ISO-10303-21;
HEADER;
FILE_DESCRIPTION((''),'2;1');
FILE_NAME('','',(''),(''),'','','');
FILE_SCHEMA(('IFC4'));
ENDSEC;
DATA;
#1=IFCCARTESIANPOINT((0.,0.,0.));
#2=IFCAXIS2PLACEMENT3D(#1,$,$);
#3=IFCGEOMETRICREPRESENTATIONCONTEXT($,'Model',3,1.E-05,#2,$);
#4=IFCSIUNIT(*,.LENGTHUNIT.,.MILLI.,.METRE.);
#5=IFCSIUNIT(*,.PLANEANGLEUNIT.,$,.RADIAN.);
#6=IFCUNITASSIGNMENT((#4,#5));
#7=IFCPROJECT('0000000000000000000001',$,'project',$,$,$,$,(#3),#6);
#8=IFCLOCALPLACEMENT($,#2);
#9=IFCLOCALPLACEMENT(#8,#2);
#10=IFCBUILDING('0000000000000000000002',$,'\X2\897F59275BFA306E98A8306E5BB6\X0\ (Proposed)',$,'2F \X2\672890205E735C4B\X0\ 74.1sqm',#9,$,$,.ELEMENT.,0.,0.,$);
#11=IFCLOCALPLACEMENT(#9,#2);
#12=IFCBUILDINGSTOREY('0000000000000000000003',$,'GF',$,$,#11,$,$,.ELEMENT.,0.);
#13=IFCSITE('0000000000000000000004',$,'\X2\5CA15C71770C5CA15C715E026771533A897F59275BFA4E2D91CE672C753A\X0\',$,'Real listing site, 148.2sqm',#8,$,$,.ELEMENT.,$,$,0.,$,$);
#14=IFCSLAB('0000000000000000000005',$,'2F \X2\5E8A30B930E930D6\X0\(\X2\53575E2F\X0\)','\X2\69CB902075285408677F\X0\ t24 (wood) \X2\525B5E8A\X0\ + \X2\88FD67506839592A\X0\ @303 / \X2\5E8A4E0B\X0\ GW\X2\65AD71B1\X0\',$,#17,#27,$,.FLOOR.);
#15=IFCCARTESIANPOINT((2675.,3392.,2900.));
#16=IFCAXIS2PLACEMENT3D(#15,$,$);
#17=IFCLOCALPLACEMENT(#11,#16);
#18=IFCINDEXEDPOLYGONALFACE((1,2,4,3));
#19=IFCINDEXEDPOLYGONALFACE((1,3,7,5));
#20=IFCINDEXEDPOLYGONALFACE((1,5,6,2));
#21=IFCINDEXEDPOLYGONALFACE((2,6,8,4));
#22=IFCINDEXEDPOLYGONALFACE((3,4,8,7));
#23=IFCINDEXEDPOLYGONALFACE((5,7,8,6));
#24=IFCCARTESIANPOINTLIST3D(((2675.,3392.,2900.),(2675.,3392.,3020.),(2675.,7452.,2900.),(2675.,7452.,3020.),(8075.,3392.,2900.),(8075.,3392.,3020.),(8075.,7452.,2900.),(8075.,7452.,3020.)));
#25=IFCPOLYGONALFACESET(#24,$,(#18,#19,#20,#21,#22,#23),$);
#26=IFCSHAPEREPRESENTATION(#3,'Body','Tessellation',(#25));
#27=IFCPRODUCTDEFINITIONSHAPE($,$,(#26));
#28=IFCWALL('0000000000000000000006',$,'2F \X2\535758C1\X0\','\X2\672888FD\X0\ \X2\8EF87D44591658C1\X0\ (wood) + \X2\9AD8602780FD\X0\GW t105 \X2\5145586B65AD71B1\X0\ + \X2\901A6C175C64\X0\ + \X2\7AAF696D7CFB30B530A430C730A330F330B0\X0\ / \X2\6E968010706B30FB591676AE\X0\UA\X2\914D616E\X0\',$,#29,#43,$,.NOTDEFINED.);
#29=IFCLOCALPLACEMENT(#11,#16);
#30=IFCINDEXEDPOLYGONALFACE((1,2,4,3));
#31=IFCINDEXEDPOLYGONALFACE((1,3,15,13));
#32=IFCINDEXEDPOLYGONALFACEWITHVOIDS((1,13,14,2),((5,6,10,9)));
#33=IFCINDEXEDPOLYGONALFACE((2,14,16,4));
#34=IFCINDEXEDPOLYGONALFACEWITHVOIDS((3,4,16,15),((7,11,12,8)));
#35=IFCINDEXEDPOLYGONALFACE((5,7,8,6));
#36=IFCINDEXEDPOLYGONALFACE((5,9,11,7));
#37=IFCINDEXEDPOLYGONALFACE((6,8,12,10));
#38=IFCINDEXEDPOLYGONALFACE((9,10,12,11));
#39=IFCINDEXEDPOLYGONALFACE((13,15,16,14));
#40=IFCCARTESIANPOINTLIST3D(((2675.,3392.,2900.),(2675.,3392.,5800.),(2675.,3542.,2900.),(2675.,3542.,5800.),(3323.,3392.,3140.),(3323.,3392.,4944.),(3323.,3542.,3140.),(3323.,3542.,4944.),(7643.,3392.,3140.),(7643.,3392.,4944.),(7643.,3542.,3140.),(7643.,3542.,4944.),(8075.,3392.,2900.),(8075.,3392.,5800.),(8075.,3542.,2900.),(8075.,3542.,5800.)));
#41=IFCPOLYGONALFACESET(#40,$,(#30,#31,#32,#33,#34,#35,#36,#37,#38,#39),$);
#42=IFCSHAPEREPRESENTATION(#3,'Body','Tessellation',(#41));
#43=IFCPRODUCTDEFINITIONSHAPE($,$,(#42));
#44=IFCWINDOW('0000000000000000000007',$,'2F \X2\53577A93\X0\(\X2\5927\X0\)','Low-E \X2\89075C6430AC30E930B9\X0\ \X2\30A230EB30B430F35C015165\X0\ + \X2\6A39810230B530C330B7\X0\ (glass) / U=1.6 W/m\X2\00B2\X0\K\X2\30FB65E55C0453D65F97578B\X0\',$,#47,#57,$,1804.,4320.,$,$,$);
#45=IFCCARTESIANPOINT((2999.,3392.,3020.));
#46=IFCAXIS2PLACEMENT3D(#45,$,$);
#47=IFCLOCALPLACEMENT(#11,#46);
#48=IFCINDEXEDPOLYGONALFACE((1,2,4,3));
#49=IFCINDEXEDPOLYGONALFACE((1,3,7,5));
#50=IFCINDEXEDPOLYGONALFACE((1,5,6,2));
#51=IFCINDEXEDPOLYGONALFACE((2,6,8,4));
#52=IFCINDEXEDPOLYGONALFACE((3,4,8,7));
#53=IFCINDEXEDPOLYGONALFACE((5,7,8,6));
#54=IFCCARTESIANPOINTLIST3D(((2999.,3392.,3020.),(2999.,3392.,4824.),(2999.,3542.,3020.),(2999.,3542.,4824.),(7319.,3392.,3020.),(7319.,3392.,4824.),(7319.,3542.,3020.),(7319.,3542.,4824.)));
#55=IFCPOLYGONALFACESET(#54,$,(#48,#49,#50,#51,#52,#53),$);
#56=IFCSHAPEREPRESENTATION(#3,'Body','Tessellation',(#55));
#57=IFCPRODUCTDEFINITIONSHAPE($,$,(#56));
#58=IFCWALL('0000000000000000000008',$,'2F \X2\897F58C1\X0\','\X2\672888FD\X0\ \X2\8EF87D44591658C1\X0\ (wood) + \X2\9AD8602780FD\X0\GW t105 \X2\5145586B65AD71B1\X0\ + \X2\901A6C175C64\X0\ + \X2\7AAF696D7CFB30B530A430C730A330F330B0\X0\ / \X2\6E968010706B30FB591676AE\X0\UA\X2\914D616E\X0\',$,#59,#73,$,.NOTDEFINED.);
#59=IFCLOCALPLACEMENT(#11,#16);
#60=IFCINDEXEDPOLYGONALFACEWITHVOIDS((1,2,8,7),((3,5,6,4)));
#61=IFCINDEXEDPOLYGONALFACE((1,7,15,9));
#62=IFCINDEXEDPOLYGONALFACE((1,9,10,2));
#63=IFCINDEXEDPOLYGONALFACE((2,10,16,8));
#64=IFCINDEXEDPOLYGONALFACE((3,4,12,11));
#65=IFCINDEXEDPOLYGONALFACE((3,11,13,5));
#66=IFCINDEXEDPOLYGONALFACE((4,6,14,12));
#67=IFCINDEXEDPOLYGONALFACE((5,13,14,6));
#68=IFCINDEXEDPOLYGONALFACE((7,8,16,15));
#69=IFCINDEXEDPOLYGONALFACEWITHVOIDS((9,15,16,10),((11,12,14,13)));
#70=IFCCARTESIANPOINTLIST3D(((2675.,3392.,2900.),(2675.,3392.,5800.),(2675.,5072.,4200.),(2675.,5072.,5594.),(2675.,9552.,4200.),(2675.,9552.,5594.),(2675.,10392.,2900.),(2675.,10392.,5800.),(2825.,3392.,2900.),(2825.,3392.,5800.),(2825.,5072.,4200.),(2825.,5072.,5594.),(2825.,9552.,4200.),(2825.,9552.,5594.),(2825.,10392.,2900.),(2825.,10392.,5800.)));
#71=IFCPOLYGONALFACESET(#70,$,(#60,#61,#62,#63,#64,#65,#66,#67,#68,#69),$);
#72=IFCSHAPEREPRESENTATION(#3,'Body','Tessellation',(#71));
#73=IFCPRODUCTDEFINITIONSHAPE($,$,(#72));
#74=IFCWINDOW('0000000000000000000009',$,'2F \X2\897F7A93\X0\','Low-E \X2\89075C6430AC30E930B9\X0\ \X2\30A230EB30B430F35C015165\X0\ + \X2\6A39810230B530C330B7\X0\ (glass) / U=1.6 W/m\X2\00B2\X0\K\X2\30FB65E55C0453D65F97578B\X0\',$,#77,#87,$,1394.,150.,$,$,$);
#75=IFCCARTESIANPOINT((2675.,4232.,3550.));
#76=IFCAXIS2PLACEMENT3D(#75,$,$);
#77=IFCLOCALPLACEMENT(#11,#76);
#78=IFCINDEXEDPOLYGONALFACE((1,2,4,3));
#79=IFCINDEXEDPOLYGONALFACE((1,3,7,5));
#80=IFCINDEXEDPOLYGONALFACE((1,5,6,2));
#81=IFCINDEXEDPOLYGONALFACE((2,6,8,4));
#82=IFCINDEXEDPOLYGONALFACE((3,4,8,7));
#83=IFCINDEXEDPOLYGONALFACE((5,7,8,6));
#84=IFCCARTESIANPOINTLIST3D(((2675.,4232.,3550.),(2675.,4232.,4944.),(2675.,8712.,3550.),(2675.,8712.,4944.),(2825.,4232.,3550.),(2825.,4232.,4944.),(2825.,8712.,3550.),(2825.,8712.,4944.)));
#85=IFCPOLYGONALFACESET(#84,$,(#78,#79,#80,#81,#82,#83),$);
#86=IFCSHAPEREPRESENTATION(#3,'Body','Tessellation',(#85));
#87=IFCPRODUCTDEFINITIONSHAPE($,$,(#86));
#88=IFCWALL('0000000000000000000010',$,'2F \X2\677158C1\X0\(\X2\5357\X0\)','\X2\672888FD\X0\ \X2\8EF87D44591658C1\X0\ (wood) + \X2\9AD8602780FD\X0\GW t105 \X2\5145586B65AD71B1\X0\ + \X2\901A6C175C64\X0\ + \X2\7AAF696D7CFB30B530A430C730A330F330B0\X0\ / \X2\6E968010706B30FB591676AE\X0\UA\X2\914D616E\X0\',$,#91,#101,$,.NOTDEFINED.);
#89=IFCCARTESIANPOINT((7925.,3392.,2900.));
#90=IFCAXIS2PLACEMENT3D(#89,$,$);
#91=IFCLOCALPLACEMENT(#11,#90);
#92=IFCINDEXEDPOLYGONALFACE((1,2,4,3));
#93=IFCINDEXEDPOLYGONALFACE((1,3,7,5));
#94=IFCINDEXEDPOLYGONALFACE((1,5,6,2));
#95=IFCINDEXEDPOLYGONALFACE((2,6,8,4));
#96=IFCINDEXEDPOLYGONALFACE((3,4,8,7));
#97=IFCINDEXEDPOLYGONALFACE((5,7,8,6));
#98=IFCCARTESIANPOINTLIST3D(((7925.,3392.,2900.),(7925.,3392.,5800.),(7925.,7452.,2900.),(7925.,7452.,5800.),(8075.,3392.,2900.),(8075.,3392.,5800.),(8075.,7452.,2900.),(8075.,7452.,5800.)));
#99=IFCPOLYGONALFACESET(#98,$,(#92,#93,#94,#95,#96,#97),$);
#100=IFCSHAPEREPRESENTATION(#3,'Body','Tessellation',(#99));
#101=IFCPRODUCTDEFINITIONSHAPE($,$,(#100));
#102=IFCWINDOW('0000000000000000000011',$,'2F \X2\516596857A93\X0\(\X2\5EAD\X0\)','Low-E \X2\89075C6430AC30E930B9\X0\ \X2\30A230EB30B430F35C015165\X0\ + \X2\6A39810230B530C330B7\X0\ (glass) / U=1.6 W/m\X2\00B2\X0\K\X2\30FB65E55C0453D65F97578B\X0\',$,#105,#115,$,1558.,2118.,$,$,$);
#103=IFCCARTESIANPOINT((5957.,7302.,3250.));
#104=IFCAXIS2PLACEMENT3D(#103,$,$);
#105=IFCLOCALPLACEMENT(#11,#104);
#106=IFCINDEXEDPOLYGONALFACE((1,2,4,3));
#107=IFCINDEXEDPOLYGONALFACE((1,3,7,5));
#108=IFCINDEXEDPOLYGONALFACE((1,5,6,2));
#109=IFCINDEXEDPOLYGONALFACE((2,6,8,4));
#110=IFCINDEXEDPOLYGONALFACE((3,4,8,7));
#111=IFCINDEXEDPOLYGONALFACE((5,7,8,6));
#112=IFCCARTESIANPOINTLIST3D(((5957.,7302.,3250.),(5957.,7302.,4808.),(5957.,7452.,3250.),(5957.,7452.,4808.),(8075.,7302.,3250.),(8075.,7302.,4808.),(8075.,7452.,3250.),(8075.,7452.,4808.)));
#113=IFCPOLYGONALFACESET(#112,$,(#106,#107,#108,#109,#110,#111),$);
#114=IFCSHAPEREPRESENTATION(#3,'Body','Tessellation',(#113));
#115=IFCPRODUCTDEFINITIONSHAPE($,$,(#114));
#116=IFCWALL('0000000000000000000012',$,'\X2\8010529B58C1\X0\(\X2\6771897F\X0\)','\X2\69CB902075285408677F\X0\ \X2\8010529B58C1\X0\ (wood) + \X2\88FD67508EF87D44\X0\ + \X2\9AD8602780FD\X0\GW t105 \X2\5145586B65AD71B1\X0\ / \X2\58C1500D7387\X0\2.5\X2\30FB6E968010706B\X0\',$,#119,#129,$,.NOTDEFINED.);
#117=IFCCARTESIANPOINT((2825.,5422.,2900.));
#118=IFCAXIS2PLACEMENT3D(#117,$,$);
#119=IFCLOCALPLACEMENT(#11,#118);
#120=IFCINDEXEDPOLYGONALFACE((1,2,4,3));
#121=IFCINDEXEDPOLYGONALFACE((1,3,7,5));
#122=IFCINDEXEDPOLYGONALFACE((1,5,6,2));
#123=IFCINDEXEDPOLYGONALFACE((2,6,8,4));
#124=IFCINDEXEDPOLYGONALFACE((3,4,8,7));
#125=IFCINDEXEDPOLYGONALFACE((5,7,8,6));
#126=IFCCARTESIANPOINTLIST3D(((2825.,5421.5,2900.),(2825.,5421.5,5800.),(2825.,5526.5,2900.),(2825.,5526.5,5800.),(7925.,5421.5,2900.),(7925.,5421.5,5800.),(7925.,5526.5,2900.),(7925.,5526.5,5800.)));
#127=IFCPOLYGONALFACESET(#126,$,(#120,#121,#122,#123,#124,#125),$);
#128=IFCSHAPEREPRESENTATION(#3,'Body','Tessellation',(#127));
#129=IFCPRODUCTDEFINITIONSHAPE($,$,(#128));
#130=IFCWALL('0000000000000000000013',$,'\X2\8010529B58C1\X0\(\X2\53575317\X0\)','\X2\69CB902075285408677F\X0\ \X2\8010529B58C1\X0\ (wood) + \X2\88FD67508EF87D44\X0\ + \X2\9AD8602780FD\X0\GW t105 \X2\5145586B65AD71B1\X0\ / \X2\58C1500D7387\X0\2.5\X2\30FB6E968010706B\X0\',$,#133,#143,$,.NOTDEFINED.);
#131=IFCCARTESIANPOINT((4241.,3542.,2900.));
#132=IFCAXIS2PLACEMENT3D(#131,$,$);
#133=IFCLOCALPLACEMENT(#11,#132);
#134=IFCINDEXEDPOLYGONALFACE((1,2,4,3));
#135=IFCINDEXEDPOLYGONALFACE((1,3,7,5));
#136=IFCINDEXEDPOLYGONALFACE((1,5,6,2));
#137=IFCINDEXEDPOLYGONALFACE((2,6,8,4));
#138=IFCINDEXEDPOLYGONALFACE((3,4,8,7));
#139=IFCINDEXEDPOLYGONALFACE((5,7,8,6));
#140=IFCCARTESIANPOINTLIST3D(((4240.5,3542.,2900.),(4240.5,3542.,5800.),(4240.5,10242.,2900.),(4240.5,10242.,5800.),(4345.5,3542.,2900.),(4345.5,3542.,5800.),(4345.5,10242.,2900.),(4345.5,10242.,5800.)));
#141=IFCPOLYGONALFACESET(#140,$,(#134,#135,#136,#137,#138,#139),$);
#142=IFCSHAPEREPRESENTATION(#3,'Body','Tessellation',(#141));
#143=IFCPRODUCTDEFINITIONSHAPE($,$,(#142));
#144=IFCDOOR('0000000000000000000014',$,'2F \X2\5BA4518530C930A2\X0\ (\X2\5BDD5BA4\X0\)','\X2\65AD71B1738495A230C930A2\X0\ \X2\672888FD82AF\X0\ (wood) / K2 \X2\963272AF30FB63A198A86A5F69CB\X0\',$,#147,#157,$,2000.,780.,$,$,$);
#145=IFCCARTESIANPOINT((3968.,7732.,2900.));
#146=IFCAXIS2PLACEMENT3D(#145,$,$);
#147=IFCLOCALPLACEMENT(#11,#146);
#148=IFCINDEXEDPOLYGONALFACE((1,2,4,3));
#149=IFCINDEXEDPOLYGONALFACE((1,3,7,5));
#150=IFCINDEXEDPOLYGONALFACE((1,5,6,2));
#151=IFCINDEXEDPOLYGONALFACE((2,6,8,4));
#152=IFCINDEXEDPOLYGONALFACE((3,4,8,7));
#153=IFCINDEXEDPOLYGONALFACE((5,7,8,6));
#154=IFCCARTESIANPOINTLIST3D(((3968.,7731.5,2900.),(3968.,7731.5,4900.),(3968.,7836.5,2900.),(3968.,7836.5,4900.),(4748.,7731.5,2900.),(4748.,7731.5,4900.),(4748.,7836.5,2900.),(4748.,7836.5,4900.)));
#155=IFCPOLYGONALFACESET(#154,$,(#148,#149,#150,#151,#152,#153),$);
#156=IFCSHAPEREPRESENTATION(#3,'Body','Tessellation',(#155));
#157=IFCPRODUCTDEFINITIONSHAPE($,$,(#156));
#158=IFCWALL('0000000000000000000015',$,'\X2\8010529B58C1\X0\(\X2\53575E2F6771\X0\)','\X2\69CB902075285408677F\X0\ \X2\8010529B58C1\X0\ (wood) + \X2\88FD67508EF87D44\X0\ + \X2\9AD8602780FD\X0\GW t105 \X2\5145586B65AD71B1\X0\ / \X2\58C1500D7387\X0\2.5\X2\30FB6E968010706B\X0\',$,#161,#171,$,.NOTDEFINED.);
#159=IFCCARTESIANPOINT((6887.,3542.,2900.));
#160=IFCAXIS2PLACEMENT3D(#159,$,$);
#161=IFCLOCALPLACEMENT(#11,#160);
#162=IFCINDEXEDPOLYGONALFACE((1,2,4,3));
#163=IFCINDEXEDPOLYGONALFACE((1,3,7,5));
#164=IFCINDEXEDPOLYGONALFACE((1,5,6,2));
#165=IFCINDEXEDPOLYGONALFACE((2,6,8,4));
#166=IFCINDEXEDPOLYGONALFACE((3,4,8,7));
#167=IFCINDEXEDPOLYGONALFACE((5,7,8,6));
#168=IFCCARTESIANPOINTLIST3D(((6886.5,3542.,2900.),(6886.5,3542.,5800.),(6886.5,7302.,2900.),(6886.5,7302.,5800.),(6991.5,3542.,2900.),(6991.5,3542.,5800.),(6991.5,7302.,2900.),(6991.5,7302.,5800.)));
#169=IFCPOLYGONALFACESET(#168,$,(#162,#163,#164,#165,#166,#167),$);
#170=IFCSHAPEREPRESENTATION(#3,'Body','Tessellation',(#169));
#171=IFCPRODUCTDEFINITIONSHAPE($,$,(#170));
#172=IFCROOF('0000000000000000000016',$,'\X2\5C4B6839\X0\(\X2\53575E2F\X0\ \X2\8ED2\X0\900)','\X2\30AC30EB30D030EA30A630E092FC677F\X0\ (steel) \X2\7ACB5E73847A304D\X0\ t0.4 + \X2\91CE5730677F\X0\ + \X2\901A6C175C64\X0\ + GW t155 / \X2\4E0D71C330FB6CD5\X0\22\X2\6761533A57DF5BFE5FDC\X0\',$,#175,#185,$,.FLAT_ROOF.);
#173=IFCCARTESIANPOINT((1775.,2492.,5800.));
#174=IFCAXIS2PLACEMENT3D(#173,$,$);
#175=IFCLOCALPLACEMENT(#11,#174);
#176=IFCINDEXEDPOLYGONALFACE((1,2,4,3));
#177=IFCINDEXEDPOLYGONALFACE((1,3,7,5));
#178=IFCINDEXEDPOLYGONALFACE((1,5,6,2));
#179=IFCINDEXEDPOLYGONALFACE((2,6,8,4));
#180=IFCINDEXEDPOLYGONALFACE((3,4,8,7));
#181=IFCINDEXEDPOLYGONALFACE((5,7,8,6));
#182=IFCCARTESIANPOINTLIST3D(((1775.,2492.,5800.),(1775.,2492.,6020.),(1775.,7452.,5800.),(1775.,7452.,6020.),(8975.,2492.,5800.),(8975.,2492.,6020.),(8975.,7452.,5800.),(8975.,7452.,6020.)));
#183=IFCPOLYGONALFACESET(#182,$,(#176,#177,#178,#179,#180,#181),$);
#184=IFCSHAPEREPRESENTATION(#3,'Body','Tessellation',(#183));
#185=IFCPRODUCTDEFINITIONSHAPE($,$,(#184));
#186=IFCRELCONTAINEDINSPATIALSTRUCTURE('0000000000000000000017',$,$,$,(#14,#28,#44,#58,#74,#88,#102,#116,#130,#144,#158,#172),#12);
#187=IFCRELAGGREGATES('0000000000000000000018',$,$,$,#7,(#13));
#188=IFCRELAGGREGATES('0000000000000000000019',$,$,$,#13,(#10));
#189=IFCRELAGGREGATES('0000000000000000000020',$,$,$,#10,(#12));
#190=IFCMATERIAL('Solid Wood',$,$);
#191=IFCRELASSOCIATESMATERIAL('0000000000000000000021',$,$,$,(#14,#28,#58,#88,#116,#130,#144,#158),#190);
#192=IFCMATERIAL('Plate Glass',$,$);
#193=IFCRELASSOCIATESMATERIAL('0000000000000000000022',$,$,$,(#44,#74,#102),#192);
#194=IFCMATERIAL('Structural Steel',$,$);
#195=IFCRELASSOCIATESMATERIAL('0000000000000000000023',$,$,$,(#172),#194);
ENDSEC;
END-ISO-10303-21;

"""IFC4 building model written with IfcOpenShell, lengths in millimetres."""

from ifc_helpers import new_model, si_unit, frame, frame_2d, origin, place, context, project, spatial, rectangle, extrude, material, element, fill, save


model = new_model("IFC4")

# Units and contexts
model_context = context("Model", 3, precision=1e-05, world=origin())
ifc_project = project(units=[si_unit("LENGTHUNIT", "METRE", prefix="MILLI"), si_unit("PLANEANGLEUNIT", "RADIAN")], contexts=[model_context])

# Site, building, storey
site_placement = place(None, origin())
site = spatial("IfcSite", under=ifc_project, at=site_placement, Name="岡山県岡山市東区西大寺中野本町", ObjectType="Real listing site, 148.2sqm", CompositionType="ELEMENT", RefElevation=0.0)
building_placement = place(site_placement, origin())
building = spatial("IfcBuilding", under=site, at=building_placement, Name="西大寺の風の家 (Proposed)", ObjectType="2F 木造平屋 74.1sqm", CompositionType="ELEMENT", ElevationOfRefHeight=0.0, ElevationOfTerrain=0.0)
storey_placement = place(building_placement, origin())
storey = spatial("IfcBuildingStorey", under=building, at=storey_placement, Name="GF", CompositionType="ELEMENT", Elevation=0.0)

# Slab
ifc_material_1 = material(Name="Solid Wood")
slab_placement = place(storey_placement, frame((2675.0, 3392.0, 2900.0)))
element("IfcSlab", 1, at=slab_placement, inside=storey, material=ifc_material_1, Name="2F 床スラブ(南帯)", Description="構造用合板 t24 (wood) 剛床 + 製材根太 @303 / 床下 GW断熱", PredefinedType="FLOOR", context=model_context, shape_type="SweptSolid", body=[
    extrude(rectangle(XDim=5400.0, YDim=4060.0, at=frame_2d((2700.0, 2030.0))), frame((2675.0, 3392.0, 2900.0)), (0.0, 0.0, 1.0), 120.0),
])

# Walls, openings, windows
wall_1_placement = place(storey_placement, frame((2675.0, 3392.0, 2900.0)))
wall_1 = element("IfcWall", 2, at=wall_1_placement, inside=storey, material=ifc_material_1, Name="2F 南壁", Description="木製 軸組外壁 (wood) + 高性能GW t105 充填断熱 + 通気層 + 窯業系サイディング / 準耐火・外皮UA配慮", PredefinedType="NOTDEFINED", context=model_context, shape_type="SweptSolid", body=[
    extrude(rectangle(XDim=5400.0, YDim=150.0, at=frame_2d((2700.0, 75.0))), frame((2675.0, 3392.0, 2900.0)), (0.0, 0.0, 1.0), 2900.0),
])
opening_1_placement = place(storey_placement, frame((2999.0, 3392.0, 3020.0)))
opening_1 = element("IfcOpeningElement", 3, at=opening_1_placement, cuts=wall_1, PredefinedType="NOTDEFINED", context=model_context, shape_type="SweptSolid", body=[
    extrude(rectangle(XDim=4320.0, YDim=150.0, at=frame_2d((2160.0, 75.0))), frame((2999.0, 3392.0, 3020.0)), (0.0, 0.0, 1.0), 1804.0),
])
ifc_material_2 = material(Name="Plate Glass")
window_1_placement = place(storey_placement, frame((2999.0, 3392.0, 3020.0)))
window_1 = element("IfcWindow", 4, at=window_1_placement, inside=storey, material=ifc_material_2, Name="2F 南窓(大)", Description="Low-E 複層ガラス アルゴン封入 + 樹脂サッシ (glass) / U=1.6 W/m²K・日射取得型", OverallHeight=1804.0, OverallWidth=4320.0, context=model_context, shape_type="SweptSolid", body=[
    extrude(rectangle(XDim=4320.0, YDim=150.0, at=frame_2d((2160.0, 75.0))), frame((2999.0, 3392.0, 3020.0)), (0.0, 0.0, 1.0), 1804.0),
])
fill(opening_1, window_1)
wall_2_placement = place(storey_placement, frame((2675.0, 3392.0, 2900.0)))
wall_2 = element("IfcWall", 5, at=wall_2_placement, inside=storey, material=ifc_material_1, Name="2F 西壁", Description="木製 軸組外壁 (wood) + 高性能GW t105 充填断熱 + 通気層 + 窯業系サイディング / 準耐火・外皮UA配慮", PredefinedType="NOTDEFINED", context=model_context, shape_type="SweptSolid", body=[
    extrude(rectangle(XDim=150.0, YDim=7000.0, at=frame_2d((75.0, 3500.0))), frame((2675.0, 3392.0, 2900.0)), (0.0, 0.0, 1.0), 2900.0),
])
opening_2_placement = place(storey_placement, frame((2675.0, 4232.0, 3550.0)))
opening_2 = element("IfcOpeningElement", 6, at=opening_2_placement, cuts=wall_2, PredefinedType="NOTDEFINED", context=model_context, shape_type="SweptSolid", body=[
    extrude(rectangle(XDim=150.0, YDim=4480.0, at=frame_2d((75.0, 2240.0))), frame((2675.0, 4232.0, 3550.0)), (0.0, 0.0, 1.0), 1394.0),
])
window_2_placement = place(storey_placement, frame((2675.0, 4232.0, 3550.0)))
window_2 = element("IfcWindow", 7, at=window_2_placement, inside=storey, material=ifc_material_2, Name="2F 西窓", Description="Low-E 複層ガラス アルゴン封入 + 樹脂サッシ (glass) / U=1.6 W/m²K・日射取得型", OverallHeight=1394.0, OverallWidth=150.0, context=model_context, shape_type="SweptSolid", body=[
    extrude(rectangle(XDim=150.0, YDim=4480.0, at=frame_2d((75.0, 2240.0))), frame((2675.0, 4232.0, 3550.0)), (0.0, 0.0, 1.0), 1394.0),
])
fill(opening_2, window_2)
wall_3_placement = place(storey_placement, frame((7925.0, 3392.0, 2900.0)))
wall_3 = element("IfcWall", 8, at=wall_3_placement, inside=storey, material=ifc_material_1, Name="2F 東壁(南)", Description="木製 軸組外壁 (wood) + 高性能GW t105 充填断熱 + 通気層 + 窯業系サイディング / 準耐火・外皮UA配慮", PredefinedType="NOTDEFINED", context=model_context, shape_type="SweptSolid", body=[
    extrude(rectangle(XDim=150.0, YDim=4060.0, at=frame_2d((75.0, 2030.0))), frame((7925.0, 3392.0, 2900.0)), (0.0, 0.0, 1.0), 2900.0),
])
opening_3_placement = place(storey_placement, frame((5957.0, 7302.0, 3250.0)))
opening_3 = element("IfcOpeningElement", 9, at=opening_3_placement, cuts=wall_3, PredefinedType="NOTDEFINED", context=model_context, shape_type="SweptSolid", body=[
    extrude(rectangle(XDim=2118.0, YDim=150.0, at=frame_2d((1059.0, 75.0))), frame((5957.0, 7302.0, 3250.0)), (0.0, 0.0, 1.0), 1558.0),
])
window_3_placement = place(storey_placement, frame((5957.0, 7302.0, 3250.0)))
window_3 = element("IfcWindow", 10, at=window_3_placement, inside=storey, material=ifc_material_2, Name="2F 入隅窓(庭)", Description="Low-E 複層ガラス アルゴン封入 + 樹脂サッシ (glass) / U=1.6 W/m²K・日射取得型", OverallHeight=1558.0, OverallWidth=2118.0, context=model_context, shape_type="SweptSolid", body=[
    extrude(rectangle(XDim=2118.0, YDim=150.0, at=frame_2d((1059.0, 75.0))), frame((5957.0, 7302.0, 3250.0)), (0.0, 0.0, 1.0), 1558.0),
])
fill(opening_3, window_3)

# Wall
wall_4_placement = place(storey_placement, frame((2825.0, 5422.0, 2900.0)))
element("IfcWall", 11, at=wall_4_placement, inside=storey, material=ifc_material_1, Name="耐力壁(東西)", Description="構造用合板 耐力壁 (wood) + 製材軸組 + 高性能GW t105 充填断熱 / 壁倍率2.5・準耐火", PredefinedType="NOTDEFINED", context=model_context, shape_type="SweptSolid", body=[
    extrude(rectangle(XDim=5100.0, YDim=105.0, at=frame_2d((2550.0, 52.0))), frame((2825.0, 5422.0, 2900.0)), (0.0, 0.0, 1.0), 2900.0),
])

# Wall, opening, door
wall_5_placement = place(storey_placement, frame((4241.0, 3542.0, 2900.0)))
wall_5 = element("IfcWall", 12, at=wall_5_placement, inside=storey, material=ifc_material_1, Name="耐力壁(南北)", Description="構造用合板 耐力壁 (wood) + 製材軸組 + 高性能GW t105 充填断熱 / 壁倍率2.5・準耐火", PredefinedType="NOTDEFINED", context=model_context, shape_type="SweptSolid", body=[
    extrude(rectangle(XDim=105.0, YDim=6700.0, at=frame_2d((52.0, 3350.0))), frame((4241.0, 3542.0, 2900.0)), (0.0, 0.0, 1.0), 2900.0),
])
opening_4_placement = place(storey_placement, frame((3968.0, 7732.0, 2900.0)))
opening_4 = element("IfcOpeningElement", 13, at=opening_4_placement, cuts=wall_5, PredefinedType="NOTDEFINED", context=model_context, shape_type="SweptSolid", body=[
    extrude(rectangle(XDim=780.0, YDim=105.0, at=frame_2d((390.0, 52.0))), frame((3968.0, 7732.0, 2900.0)), (0.0, 0.0, 1.0), 2000.0),
])
door_placement = place(storey_placement, frame((3968.0, 7732.0, 2900.0)))
door = element("IfcDoor", 14, at=door_placement, inside=storey, material=ifc_material_1, Name="2F 室内ドア (寝室)", Description="断熱玄関ドア 木製芯 (wood) / K2 防犯・採風機構", OverallHeight=2000.0, OverallWidth=780.0, context=model_context, shape_type="SweptSolid", body=[
    extrude(rectangle(XDim=780.0, YDim=105.0, at=frame_2d((390.0, 52.0))), frame((3968.0, 7732.0, 2900.0)), (0.0, 0.0, 1.0), 2000.0),
])
fill(opening_4, door)

# Wall
wall_6_placement = place(storey_placement, frame((6887.0, 3542.0, 2900.0)))
element("IfcWall", 15, at=wall_6_placement, inside=storey, material=ifc_material_1, Name="耐力壁(南帯東)", Description="構造用合板 耐力壁 (wood) + 製材軸組 + 高性能GW t105 充填断熱 / 壁倍率2.5・準耐火", PredefinedType="NOTDEFINED", context=model_context, shape_type="SweptSolid", body=[
    extrude(rectangle(XDim=105.0, YDim=3760.0, at=frame_2d((52.0, 1880.0))), frame((6887.0, 3542.0, 2900.0)), (0.0, 0.0, 1.0), 2900.0),
])

# Roof
ifc_material_3 = material(Name="Structural Steel")
for number, where, name in (
    (16, (1775.0, 2492.0, 5800.0), "屋根(南帯 軒900)"),
):
    element("IfcRoof", number, at=place(storey_placement, frame(where)), inside=storey, material=ifc_material_3, Name=name, Description="ガルバリウム鋼板 (steel) 立平葺き t0.4 + 野地板 + 通気層 + GW t155 / 不燃・法22条区域対応", PredefinedType="FLAT_ROOF", context=model_context, shape_type="SweptSolid", body=[
        extrude(rectangle(XDim=7200.0, YDim=4960.0, at=frame_2d((3600.0, 2480.0))), frame((1775.0, 2492.0, 5800.0)), (0.0, 0.0, 1.0), 220.0),
    ])

save(model, "model.ifc")
